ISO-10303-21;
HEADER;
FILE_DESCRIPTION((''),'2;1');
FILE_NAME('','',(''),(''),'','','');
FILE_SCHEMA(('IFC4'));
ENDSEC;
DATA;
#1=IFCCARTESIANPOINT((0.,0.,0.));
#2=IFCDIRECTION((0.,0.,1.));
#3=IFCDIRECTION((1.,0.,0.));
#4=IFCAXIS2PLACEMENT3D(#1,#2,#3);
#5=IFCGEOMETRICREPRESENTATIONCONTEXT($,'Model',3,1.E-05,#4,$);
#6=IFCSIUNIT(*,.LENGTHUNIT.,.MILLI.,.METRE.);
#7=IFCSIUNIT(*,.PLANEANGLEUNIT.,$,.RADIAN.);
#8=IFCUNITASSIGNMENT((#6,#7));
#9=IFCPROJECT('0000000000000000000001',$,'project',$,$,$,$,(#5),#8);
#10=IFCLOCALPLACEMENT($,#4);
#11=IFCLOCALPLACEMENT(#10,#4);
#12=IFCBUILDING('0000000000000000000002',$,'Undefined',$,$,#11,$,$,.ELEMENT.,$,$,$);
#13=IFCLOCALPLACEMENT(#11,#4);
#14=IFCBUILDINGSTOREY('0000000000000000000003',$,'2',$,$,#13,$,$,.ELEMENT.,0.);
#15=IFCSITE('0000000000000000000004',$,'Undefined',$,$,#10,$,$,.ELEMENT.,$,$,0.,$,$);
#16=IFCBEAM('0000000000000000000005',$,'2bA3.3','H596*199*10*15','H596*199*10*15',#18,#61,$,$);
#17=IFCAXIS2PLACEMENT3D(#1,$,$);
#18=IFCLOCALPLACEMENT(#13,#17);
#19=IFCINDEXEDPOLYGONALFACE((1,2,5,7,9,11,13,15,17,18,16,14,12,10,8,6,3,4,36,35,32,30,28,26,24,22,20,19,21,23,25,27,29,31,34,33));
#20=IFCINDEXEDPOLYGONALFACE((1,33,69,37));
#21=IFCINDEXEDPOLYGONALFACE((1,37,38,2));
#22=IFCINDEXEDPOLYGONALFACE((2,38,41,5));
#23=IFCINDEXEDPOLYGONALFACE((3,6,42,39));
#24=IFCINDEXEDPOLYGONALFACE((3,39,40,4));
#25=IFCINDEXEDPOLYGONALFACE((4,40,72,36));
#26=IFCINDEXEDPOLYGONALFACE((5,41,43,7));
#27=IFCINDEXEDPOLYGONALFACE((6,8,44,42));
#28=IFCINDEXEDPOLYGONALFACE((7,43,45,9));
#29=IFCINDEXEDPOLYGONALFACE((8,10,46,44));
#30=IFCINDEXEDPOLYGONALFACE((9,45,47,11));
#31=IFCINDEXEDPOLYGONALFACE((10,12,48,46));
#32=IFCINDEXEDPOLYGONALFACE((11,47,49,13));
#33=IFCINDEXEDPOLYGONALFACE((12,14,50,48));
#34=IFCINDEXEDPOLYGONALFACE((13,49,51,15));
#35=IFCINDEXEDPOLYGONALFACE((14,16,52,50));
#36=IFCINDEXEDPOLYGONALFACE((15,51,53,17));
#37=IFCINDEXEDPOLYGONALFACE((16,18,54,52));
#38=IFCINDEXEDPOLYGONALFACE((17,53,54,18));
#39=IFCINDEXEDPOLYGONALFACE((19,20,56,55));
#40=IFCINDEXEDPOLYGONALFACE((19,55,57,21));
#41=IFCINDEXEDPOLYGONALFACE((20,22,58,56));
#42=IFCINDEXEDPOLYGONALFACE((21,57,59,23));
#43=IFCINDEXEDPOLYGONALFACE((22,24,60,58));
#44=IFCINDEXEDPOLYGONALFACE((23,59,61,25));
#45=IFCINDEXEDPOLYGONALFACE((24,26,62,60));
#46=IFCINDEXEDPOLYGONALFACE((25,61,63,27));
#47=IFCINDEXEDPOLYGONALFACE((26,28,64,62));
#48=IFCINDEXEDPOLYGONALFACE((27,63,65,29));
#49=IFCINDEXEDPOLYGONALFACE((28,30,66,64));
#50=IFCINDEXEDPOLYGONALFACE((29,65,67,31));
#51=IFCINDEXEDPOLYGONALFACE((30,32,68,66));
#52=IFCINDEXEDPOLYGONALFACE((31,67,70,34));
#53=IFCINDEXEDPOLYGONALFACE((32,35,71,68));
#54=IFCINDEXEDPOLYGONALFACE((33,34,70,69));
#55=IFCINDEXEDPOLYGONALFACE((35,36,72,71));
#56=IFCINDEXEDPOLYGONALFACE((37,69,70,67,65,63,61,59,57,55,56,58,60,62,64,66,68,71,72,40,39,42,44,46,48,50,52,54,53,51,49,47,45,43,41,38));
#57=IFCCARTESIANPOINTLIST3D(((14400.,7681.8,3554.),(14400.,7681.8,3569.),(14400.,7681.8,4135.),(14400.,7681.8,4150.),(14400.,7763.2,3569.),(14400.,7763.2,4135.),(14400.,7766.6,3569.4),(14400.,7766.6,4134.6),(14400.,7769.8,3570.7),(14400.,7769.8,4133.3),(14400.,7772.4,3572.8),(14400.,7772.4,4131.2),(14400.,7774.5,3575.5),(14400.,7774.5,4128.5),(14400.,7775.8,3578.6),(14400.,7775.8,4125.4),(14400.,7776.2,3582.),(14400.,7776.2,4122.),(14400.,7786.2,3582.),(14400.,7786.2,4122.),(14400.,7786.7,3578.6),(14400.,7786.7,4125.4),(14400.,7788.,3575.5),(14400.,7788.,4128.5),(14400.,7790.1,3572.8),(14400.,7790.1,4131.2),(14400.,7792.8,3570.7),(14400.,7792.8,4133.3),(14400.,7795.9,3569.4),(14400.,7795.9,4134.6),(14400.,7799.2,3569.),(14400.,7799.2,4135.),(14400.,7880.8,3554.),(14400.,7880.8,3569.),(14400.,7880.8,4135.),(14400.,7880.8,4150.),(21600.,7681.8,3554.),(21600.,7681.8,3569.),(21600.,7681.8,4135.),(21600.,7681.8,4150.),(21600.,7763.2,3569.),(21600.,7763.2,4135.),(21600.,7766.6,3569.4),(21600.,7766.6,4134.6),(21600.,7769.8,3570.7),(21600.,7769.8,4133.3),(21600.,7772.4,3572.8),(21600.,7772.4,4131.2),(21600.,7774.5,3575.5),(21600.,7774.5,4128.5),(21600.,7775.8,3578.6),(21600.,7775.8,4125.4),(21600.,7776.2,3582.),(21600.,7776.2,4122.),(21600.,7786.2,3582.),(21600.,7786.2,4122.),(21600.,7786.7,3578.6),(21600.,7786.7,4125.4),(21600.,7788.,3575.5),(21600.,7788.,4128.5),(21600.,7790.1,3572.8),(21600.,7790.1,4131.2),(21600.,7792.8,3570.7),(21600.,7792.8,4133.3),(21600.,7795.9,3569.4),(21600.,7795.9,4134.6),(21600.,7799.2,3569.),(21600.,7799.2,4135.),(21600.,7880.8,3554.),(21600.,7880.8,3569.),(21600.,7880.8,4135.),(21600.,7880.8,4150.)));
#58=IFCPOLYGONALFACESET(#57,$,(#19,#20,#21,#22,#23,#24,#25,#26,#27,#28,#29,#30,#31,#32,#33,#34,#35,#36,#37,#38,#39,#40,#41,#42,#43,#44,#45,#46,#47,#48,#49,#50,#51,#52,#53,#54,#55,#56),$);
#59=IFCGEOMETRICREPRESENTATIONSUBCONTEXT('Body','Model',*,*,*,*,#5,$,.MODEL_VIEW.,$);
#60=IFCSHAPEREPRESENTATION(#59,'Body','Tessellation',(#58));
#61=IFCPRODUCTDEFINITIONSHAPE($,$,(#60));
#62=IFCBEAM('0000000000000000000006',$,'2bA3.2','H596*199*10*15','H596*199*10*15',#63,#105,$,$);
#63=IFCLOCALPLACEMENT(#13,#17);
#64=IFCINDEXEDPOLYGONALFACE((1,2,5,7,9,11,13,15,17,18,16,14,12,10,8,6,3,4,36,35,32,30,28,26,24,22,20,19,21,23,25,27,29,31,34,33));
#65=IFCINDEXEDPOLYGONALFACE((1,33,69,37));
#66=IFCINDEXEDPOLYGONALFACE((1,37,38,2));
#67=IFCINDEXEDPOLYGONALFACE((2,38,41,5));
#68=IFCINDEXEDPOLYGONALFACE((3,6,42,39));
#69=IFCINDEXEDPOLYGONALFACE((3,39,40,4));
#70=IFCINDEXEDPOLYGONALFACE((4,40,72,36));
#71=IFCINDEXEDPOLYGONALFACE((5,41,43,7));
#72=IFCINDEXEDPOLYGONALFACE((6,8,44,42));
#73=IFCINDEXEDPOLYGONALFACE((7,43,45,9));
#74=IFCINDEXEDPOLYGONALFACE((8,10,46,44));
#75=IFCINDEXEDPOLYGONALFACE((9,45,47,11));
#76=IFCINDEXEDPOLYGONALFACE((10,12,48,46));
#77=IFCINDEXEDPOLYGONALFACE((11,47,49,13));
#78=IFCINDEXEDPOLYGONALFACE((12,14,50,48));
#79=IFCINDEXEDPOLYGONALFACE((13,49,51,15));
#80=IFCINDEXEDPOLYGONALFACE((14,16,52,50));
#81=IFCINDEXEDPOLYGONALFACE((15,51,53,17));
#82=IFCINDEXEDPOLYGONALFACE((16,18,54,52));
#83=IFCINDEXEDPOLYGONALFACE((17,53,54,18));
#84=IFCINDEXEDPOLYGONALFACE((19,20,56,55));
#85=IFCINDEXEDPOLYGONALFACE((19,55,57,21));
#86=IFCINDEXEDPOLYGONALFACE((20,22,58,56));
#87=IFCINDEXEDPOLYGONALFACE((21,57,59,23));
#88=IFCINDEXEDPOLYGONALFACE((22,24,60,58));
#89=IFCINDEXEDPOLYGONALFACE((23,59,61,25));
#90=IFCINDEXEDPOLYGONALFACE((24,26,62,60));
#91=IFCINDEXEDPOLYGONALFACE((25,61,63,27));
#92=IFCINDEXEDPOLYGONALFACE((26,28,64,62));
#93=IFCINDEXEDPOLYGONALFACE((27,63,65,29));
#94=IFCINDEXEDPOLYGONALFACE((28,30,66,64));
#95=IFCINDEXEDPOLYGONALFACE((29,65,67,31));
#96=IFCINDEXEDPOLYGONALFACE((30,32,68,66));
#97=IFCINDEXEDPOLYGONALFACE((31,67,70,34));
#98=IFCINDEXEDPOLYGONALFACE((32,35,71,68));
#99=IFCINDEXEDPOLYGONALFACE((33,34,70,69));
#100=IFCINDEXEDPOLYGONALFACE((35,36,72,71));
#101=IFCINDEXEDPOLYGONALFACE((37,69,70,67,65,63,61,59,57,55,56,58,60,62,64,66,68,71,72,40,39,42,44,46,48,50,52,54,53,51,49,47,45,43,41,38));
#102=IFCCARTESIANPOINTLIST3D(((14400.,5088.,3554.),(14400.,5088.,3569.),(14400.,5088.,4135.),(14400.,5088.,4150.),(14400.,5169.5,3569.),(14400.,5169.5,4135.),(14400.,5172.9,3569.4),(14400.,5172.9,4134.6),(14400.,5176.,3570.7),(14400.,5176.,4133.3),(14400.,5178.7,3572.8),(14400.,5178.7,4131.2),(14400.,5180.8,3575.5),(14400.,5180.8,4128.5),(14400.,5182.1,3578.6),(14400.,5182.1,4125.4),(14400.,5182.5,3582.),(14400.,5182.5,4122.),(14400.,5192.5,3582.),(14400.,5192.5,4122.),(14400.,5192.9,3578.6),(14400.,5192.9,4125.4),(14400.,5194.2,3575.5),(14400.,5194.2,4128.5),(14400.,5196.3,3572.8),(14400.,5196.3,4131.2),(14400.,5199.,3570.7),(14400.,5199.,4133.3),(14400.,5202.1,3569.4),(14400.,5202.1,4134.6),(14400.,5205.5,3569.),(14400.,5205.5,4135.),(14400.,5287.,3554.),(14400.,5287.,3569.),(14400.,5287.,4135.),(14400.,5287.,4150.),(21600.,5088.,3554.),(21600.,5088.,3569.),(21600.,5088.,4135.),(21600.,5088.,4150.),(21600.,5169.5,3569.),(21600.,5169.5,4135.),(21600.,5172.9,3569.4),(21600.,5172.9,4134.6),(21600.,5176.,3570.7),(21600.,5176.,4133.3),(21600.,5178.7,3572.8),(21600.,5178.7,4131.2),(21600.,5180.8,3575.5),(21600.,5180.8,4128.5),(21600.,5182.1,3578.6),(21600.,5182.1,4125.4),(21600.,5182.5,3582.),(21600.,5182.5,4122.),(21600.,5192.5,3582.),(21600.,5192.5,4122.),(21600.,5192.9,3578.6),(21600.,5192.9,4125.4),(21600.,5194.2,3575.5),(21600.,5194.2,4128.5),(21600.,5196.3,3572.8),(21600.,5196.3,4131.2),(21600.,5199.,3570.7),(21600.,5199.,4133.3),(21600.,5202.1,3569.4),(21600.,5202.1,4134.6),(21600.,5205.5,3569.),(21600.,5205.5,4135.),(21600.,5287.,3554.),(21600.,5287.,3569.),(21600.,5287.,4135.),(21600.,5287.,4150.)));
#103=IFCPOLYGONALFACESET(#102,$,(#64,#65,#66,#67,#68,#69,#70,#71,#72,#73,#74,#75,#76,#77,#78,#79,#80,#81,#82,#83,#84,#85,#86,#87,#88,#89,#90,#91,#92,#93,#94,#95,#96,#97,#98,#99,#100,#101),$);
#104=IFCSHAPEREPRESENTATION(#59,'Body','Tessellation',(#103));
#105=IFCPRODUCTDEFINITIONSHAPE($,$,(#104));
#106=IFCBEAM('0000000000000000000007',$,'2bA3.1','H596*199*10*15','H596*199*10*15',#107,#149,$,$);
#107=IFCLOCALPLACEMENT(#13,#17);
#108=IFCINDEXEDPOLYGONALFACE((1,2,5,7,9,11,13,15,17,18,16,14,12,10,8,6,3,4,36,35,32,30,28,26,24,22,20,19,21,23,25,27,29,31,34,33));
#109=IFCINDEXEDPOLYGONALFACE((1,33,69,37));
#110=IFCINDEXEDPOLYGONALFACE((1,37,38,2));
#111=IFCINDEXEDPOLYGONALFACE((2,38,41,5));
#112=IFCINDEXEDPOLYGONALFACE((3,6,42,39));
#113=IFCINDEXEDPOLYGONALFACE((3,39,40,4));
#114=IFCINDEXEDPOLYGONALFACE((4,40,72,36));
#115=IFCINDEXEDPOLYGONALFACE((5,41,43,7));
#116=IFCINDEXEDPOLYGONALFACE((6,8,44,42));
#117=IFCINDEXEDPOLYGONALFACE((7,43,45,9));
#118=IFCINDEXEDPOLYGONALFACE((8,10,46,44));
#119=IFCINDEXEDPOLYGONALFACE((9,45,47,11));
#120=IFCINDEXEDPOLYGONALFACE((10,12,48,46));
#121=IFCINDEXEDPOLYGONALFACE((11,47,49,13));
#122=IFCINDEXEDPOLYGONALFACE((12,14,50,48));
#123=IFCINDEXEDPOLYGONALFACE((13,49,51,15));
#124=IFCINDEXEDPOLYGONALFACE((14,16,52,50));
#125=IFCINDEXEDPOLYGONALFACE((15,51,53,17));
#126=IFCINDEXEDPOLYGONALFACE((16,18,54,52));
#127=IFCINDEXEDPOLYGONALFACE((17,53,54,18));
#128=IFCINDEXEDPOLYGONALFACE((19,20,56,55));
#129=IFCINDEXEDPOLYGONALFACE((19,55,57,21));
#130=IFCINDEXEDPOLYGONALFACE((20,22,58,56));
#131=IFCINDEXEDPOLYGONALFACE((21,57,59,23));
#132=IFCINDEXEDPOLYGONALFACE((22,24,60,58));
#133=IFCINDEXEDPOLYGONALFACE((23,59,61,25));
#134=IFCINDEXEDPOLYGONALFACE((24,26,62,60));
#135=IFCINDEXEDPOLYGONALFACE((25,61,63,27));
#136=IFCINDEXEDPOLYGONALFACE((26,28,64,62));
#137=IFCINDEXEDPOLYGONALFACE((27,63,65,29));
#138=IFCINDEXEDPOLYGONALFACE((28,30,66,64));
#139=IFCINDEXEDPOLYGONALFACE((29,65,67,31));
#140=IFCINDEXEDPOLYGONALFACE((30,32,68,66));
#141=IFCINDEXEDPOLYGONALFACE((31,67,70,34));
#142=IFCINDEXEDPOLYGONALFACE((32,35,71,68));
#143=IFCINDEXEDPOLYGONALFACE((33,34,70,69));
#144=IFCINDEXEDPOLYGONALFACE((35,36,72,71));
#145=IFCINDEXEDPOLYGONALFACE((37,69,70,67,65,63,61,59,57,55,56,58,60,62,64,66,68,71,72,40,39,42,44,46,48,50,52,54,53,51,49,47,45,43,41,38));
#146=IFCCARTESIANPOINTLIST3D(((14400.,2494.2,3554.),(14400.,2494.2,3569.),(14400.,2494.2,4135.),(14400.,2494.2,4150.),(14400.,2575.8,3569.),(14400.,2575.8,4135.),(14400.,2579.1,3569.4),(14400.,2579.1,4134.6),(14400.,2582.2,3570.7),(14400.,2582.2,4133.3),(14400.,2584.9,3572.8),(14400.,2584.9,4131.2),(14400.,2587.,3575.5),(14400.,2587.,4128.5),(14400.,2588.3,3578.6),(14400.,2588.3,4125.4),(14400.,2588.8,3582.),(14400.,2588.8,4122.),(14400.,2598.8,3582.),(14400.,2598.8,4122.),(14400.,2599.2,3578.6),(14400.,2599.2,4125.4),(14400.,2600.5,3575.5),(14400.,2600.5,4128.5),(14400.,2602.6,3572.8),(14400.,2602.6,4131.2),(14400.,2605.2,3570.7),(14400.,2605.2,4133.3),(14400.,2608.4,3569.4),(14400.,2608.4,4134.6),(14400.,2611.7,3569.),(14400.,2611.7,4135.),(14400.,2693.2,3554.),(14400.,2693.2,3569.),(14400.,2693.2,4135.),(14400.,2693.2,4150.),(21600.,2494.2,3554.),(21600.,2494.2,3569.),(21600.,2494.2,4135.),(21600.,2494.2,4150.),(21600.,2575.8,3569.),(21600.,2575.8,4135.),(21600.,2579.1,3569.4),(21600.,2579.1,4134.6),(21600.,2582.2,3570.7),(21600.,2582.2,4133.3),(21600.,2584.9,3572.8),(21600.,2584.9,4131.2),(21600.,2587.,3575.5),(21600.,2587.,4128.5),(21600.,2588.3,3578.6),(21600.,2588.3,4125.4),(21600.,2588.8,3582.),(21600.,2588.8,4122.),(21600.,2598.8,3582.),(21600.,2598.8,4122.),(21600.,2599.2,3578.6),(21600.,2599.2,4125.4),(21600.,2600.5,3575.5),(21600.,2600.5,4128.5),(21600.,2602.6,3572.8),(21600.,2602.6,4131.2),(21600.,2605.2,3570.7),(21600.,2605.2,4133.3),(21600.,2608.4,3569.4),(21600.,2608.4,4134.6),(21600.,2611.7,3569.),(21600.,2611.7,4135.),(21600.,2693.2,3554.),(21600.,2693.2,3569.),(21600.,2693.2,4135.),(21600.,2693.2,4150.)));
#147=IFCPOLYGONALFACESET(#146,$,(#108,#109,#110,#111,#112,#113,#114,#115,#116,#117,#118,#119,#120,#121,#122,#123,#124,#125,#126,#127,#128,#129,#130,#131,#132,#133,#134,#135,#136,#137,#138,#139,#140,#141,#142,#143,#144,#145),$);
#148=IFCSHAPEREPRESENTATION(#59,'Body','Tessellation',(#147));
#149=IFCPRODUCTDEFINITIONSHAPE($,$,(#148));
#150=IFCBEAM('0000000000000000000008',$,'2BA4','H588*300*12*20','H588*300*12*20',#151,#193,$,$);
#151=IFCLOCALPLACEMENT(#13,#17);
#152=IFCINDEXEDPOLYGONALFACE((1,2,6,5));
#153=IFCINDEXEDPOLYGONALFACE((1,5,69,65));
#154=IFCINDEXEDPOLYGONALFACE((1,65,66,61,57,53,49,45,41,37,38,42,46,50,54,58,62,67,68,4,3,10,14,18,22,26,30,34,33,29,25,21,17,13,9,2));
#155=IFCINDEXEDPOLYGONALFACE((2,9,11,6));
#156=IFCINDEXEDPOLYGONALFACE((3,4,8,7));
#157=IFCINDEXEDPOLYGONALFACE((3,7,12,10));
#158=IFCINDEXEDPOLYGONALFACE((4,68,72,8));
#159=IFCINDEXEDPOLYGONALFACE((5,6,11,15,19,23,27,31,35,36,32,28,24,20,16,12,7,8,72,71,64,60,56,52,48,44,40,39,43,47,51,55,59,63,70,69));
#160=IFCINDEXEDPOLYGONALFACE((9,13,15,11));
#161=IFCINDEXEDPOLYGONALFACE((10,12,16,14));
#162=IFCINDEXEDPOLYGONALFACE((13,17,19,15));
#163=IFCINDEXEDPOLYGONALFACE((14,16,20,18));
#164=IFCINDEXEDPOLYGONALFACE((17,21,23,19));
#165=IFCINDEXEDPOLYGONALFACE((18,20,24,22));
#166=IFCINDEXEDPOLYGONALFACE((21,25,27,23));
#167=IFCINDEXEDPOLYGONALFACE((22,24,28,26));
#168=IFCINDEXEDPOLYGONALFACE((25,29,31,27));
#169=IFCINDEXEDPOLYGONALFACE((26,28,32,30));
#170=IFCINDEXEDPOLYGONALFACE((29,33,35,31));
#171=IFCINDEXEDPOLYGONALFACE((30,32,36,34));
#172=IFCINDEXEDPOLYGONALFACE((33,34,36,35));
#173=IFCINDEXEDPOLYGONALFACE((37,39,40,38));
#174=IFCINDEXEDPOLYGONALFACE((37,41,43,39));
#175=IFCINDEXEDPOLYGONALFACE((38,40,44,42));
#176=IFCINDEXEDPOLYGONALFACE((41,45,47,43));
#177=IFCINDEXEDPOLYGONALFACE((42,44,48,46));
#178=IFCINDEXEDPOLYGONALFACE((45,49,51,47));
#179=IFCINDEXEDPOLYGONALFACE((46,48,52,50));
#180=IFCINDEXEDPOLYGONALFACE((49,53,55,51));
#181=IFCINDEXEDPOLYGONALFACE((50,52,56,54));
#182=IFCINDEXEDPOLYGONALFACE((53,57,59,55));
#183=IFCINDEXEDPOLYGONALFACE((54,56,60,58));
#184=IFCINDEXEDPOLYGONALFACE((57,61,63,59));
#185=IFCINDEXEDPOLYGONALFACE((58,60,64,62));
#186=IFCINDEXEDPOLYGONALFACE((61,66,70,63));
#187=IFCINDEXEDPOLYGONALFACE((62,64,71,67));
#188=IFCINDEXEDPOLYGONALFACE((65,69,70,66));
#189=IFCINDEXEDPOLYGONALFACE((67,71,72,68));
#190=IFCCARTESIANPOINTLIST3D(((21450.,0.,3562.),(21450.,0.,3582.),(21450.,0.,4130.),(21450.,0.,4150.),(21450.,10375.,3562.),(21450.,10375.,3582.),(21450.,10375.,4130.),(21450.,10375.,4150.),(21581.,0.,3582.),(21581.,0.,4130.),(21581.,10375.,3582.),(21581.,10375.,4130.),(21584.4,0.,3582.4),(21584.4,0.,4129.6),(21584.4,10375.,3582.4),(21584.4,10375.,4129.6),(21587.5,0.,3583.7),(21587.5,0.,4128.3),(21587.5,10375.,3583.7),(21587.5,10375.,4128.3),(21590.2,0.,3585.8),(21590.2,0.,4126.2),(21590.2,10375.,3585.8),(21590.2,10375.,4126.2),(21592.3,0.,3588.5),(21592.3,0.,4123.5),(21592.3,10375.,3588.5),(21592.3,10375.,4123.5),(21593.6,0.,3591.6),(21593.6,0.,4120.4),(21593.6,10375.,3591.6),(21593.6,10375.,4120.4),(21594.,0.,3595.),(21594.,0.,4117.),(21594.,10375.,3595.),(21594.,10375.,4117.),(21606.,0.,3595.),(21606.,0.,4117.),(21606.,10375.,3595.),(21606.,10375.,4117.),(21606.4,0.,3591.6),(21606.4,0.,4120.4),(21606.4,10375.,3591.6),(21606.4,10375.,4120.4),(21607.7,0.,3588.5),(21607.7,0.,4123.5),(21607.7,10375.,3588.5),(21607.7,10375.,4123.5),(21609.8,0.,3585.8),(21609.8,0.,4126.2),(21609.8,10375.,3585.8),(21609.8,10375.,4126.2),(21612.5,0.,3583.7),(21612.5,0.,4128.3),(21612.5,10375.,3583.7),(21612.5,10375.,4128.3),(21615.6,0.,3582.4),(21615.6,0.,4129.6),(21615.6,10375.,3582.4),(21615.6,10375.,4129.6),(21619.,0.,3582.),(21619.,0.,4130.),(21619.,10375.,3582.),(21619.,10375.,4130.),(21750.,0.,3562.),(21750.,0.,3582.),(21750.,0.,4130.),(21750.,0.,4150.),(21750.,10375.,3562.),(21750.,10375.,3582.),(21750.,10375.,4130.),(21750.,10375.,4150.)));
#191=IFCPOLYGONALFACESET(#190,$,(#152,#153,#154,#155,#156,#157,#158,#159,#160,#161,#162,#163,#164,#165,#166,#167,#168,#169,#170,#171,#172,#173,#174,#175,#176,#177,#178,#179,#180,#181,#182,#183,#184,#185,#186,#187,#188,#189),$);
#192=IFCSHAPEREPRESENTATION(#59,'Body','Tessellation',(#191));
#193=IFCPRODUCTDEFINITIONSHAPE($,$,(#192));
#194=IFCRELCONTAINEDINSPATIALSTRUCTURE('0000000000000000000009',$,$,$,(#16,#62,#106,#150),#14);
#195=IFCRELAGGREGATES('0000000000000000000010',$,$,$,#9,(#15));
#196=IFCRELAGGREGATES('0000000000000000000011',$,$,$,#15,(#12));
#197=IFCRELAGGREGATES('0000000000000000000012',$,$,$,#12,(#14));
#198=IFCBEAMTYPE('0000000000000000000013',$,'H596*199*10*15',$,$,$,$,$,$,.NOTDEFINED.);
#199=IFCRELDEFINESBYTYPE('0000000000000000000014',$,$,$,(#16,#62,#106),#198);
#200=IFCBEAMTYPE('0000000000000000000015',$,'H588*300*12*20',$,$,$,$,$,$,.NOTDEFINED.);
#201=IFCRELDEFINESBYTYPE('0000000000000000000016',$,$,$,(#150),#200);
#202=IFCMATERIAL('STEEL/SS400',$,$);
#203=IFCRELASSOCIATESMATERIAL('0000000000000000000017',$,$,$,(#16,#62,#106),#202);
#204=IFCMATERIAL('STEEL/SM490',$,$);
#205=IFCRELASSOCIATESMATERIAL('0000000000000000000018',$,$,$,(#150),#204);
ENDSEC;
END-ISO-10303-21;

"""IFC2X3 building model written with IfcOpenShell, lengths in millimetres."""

from ifc_helpers import new_model, si_unit, frame, origin_with_axes, origin_2d_with_axis, place, context, subcontext, project, spatial, i_section, extrude, material, type_object, element, save


model = new_model("IFC2X3")

# Units and contexts
model_context = context("Model", 3, precision=1e-05, world=origin_with_axes())
body_context = subcontext(model_context, "Body", "Model", "MODEL_VIEW")
ifc_project = project(units=[si_unit("LENGTHUNIT", "METRE", prefix="MILLI"), si_unit("PLANEANGLEUNIT", "RADIAN")], contexts=[model_context])

# Site, building, storey
site_placement = place(None, origin_with_axes())
site = spatial("IfcSite", under=ifc_project, at=site_placement, Name="Undefined", CompositionType="ELEMENT", RefElevation=0.0)
building_placement = place(site_placement, origin_with_axes())
building = spatial("IfcBuilding", under=site, at=building_placement, Name="Undefined", CompositionType="ELEMENT")
storey_placement = place(building_placement, origin_with_axes())
storey = spatial("IfcBuildingStorey", under=building, at=storey_placement, Name="2", CompositionType="ELEMENT", Elevation=0.0)

# Shared definitions
ifc_material_1 = material(Name="STEEL/SM490")

# Beams
ifc_material_2 = material(Name="STEEL/SS400")
beam_type_1 = type_object("IfcBeamType", Name="H596*199*10*15", PredefinedType="NOTDEFINED")
for number, where, z_axis, x_axis, name in (
    (1, (14400.0, 7781.2, 3852.0), (0.0, 0.0, 1.0), (1.0, 0.0, 0.0), "2bA3.3"),
    (2, (14400.0, 5187.5, 3852.0), (0.0, 0.0, 1.0), (1.0, 0.0, 0.0), "2bA3.2"),
    (3, (14400.0, 2593.8, 3852.0), (0.0, 0.0, 1.0), (1.0, 0.0, 0.0), "2bA3.1"),
):
    element("IfcBeam", number, at=place(storey_placement, frame(where, z_axis=z_axis, x_axis=x_axis)), inside=storey, type_object=beam_type_1, material=ifc_material_2, Name=name, Description="H596*199*10*15", ObjectType="H596*199*10*15", context=body_context, shape_type="SweptSolid", body=[
        extrude(i_section(OverallWidth=199.0, OverallDepth=596.0, WebThickness=10.0, FlangeThickness=15.0, FilletRadius=13.0, at=origin_2d_with_axis()), frame((7200.0, 0.0, 0.0), z_axis=(-1.0, 0.0, 0.0), x_axis=(0.0, -1.0, 0.0)), (0.0, 0.0, 1.0), 7200.0),
    ])
beam_type_2 = type_object("IfcBeamType", Name="H588*300*12*20", PredefinedType="NOTDEFINED")
for number, where, z_axis, x_axis, name in (
    (4, (21600.0, 0.0, 3856.0), (0.0, 0.0, 1.0), (0.0, 1.0, 0.0), "2BA4"),
):
    element("IfcBeam", number, at=place(storey_placement, frame(where, z_axis=z_axis, x_axis=x_axis)), inside=storey, type_object=beam_type_2, material=ifc_material_1, Name=name, Description="H588*300*12*20", ObjectType="H588*300*12*20", context=body_context, shape_type="SweptSolid", body=[
        extrude(i_section(OverallWidth=300.0, OverallDepth=588.0, WebThickness=12.0, FlangeThickness=20.0, FilletRadius=13.0, at=origin_2d_with_axis()), frame((10375.0, 0.0, 0.0), z_axis=(-1.0, 0.0, 0.0), x_axis=(0.0, -1.0, 0.0)), (0.0, 0.0, 1.0), 10375.0),
    ])

save(model, "model.ifc")
